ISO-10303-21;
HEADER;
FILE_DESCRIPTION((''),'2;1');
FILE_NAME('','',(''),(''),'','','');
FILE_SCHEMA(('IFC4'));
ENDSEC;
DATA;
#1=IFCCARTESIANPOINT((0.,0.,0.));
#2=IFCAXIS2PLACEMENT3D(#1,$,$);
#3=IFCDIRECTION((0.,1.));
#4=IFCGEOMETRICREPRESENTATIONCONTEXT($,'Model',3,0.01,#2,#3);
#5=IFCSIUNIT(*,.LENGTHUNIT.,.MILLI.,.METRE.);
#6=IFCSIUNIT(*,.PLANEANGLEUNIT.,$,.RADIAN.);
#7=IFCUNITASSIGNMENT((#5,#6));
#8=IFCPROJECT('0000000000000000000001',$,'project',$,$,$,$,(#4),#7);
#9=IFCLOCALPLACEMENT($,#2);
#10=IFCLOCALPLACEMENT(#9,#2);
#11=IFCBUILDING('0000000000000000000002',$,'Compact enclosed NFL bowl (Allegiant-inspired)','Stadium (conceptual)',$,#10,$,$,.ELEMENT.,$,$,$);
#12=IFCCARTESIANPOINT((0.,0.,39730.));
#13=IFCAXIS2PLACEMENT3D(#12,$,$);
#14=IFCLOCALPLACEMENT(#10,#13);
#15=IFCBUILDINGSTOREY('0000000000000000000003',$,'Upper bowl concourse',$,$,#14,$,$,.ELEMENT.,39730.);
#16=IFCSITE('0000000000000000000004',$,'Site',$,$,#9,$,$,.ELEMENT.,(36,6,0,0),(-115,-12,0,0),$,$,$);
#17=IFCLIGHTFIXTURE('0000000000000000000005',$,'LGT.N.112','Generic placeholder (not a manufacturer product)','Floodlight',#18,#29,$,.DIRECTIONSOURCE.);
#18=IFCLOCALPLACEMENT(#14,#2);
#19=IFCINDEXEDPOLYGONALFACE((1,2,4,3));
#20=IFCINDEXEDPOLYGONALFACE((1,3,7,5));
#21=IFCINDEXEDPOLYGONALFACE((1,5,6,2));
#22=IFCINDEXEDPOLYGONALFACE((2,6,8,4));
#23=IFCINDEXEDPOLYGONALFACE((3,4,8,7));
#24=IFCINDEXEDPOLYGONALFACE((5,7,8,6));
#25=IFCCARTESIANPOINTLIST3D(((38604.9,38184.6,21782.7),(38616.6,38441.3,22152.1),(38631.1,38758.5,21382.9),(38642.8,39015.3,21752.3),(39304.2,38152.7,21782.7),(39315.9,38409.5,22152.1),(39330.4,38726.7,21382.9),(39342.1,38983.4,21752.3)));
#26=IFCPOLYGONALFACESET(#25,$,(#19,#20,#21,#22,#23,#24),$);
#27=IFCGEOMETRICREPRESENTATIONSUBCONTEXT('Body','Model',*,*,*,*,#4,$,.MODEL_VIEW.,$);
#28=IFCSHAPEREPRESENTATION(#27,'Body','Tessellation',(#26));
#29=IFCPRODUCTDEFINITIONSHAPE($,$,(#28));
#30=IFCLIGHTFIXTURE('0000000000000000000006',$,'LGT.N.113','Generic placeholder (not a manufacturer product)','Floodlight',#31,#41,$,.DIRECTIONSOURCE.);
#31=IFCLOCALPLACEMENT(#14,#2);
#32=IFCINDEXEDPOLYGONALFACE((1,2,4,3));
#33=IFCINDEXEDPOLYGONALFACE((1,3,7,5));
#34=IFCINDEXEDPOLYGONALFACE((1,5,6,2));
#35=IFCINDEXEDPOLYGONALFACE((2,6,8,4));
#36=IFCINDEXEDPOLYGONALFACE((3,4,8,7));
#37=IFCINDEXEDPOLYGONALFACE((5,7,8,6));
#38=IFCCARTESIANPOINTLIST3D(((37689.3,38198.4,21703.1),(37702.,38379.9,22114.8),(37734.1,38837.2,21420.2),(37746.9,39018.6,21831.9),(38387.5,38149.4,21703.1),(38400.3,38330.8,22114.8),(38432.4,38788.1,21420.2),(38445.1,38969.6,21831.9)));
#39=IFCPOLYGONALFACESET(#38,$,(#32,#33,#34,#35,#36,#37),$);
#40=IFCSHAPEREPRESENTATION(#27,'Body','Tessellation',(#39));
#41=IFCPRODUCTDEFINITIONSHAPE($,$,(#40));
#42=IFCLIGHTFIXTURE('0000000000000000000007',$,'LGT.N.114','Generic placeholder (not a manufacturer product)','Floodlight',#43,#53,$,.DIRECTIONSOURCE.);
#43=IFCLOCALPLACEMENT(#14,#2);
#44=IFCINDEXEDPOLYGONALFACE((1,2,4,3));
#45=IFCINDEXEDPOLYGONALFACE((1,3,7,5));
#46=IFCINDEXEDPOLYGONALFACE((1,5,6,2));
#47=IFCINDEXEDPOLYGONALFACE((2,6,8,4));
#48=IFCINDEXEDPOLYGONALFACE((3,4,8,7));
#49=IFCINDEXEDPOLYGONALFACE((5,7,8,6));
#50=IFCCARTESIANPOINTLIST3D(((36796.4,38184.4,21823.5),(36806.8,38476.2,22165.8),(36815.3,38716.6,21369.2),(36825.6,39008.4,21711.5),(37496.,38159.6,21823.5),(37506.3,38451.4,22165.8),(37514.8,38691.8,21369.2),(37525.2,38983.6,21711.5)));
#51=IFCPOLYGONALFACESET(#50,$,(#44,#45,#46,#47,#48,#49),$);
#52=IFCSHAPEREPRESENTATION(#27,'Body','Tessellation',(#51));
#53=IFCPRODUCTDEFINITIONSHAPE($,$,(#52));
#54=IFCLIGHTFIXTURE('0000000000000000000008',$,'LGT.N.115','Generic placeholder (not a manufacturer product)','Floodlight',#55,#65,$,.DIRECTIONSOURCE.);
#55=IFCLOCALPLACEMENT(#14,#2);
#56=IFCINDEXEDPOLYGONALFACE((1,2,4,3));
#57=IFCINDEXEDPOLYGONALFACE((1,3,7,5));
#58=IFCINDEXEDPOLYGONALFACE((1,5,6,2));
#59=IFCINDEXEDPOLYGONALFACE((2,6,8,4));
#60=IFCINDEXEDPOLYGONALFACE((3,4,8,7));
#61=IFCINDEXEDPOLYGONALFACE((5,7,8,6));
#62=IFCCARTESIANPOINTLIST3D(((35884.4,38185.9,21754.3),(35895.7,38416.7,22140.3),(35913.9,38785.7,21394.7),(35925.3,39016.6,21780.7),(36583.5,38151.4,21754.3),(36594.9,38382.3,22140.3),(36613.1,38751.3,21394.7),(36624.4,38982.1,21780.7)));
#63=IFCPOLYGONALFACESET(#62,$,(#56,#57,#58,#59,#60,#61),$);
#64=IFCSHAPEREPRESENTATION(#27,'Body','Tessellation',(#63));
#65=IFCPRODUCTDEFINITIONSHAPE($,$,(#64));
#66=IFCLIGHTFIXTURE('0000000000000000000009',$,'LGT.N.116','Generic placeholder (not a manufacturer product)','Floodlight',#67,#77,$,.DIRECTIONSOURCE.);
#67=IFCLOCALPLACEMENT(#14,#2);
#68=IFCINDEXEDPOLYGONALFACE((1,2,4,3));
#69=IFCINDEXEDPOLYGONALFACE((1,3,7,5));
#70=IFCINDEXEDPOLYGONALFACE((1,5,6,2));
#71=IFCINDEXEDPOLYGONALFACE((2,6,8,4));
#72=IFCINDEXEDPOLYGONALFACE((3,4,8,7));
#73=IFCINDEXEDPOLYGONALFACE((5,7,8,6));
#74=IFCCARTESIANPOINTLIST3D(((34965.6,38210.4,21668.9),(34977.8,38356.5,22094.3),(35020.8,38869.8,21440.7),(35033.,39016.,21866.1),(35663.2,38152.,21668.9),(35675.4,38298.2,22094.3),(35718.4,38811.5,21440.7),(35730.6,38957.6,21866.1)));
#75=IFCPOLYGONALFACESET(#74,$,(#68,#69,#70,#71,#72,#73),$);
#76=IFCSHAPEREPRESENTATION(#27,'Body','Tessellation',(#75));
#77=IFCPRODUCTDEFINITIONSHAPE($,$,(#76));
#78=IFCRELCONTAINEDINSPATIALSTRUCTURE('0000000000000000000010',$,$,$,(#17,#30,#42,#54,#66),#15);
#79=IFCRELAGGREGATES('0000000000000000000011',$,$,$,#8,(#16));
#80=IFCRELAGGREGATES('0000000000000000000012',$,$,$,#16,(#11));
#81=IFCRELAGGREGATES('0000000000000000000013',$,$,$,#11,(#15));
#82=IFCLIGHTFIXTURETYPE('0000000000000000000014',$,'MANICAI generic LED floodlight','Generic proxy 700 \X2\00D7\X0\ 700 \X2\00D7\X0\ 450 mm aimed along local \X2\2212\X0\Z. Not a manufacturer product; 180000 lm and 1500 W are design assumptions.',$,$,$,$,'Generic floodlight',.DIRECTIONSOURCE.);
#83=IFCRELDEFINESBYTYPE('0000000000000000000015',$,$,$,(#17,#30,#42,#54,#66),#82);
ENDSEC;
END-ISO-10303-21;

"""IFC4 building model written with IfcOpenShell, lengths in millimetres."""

from ifc_helpers import new_model, si_unit, direction, frame, origin, place, context, subcontext, project, spatial, rectangle, extrude, source, transform, mapped, type_object, type_shapes, element, save


model = new_model("IFC4")

# Units and contexts
model_context = context("Model", 3, precision=0.01, world=origin(), true_north=direction((0.0, 1.0)))
body_context = subcontext(model_context, "Body", "Model", "MODEL_VIEW")
ifc_project = project(units=[si_unit("LENGTHUNIT", "METRE", prefix="MILLI"), si_unit("PLANEANGLEUNIT", "RADIAN")], contexts=[model_context])

# Site, building, storey
site_placement = place(None, origin())
site = spatial("IfcSite", under=ifc_project, at=site_placement, Name="Site", CompositionType="ELEMENT", RefLatitude=(36, 6, 0, 0), RefLongitude=(-115, -12, 0, 0))
building_placement = place(site_placement, origin())
building = spatial("IfcBuilding", under=site, at=building_placement, Name="Compact enclosed NFL bowl (Allegiant-inspired)", Description="Stadium (conceptual)", CompositionType="ELEMENT")
storey_placement = place(building_placement, frame((0.0, 0.0, 39730.0)))
storey = spatial("IfcBuildingStorey", under=building, at=storey_placement, Name="Upper bowl concourse", CompositionType="ELEMENT", Elevation=39730.0)

# Light fixtures
light_fixture_type = type_object("IfcLightFixtureType", Name="MANICAI generic LED floodlight", Description="Generic proxy 700 × 700 × 450 mm aimed along local −Z. Not a manufacturer product; 180000 lm and 1500 W are design assumptions.", ElementType="Generic floodlight", PredefinedType="DIRECTIONSOURCE")
shared_shape = source(origin(), body_context, "Body", "SweptSolid", [
    extrude(rectangle(XDim=700.0, YDim=700.0), frame((0.0, 0.0, -225.0)), (0.0, 0.0, 1.0), 450.0),
])
type_shapes(light_fixture_type, [shared_shape])
for number, where, z_axis, x_axis, name in (
    (1, (38973.5, 38584.0, 21767.5), (0.026009, 0.570622, 0.820801), (-0.998963, 0.045532, 0.0), "LGT.N.112"),
    (2, (38067.2, 38584.0, 21767.5), (0.02831, 0.403162, 0.914691), (-0.997544, 0.070047, 0.0), "LGT.N.113"),
    (3, (37160.8, 38584.0, 21767.5), (0.022987, 0.64856, 0.760816), (-0.999372, 0.035421, 0.0), "LGT.N.114"),
    (4, (36254.4, 38584.0, 21767.5), (0.02529, 0.513078, 0.857969), (-0.998787, 0.049231, 0.0), "LGT.N.115"),
    (5, (35348.1, 38584.0, 21767.5), (0.02717, 0.324813, 0.945388), (-0.99652, 0.083357, 0.0), "LGT.N.116"),
):
    element("IfcLightFixture", number, at=place(storey_placement, frame(where, z_axis=z_axis, x_axis=x_axis)), inside=storey, type_object=light_fixture_type, Name=name, Description="Generic placeholder (not a manufacturer product)", ObjectType="Floodlight", PredefinedType="DIRECTIONSOURCE", context=body_context, shape_type="MappedRepresentation", body=[
        mapped(shared_shape, transform((0.0, 0.0, 0.0))),
    ])

save(model, "model.ifc")
